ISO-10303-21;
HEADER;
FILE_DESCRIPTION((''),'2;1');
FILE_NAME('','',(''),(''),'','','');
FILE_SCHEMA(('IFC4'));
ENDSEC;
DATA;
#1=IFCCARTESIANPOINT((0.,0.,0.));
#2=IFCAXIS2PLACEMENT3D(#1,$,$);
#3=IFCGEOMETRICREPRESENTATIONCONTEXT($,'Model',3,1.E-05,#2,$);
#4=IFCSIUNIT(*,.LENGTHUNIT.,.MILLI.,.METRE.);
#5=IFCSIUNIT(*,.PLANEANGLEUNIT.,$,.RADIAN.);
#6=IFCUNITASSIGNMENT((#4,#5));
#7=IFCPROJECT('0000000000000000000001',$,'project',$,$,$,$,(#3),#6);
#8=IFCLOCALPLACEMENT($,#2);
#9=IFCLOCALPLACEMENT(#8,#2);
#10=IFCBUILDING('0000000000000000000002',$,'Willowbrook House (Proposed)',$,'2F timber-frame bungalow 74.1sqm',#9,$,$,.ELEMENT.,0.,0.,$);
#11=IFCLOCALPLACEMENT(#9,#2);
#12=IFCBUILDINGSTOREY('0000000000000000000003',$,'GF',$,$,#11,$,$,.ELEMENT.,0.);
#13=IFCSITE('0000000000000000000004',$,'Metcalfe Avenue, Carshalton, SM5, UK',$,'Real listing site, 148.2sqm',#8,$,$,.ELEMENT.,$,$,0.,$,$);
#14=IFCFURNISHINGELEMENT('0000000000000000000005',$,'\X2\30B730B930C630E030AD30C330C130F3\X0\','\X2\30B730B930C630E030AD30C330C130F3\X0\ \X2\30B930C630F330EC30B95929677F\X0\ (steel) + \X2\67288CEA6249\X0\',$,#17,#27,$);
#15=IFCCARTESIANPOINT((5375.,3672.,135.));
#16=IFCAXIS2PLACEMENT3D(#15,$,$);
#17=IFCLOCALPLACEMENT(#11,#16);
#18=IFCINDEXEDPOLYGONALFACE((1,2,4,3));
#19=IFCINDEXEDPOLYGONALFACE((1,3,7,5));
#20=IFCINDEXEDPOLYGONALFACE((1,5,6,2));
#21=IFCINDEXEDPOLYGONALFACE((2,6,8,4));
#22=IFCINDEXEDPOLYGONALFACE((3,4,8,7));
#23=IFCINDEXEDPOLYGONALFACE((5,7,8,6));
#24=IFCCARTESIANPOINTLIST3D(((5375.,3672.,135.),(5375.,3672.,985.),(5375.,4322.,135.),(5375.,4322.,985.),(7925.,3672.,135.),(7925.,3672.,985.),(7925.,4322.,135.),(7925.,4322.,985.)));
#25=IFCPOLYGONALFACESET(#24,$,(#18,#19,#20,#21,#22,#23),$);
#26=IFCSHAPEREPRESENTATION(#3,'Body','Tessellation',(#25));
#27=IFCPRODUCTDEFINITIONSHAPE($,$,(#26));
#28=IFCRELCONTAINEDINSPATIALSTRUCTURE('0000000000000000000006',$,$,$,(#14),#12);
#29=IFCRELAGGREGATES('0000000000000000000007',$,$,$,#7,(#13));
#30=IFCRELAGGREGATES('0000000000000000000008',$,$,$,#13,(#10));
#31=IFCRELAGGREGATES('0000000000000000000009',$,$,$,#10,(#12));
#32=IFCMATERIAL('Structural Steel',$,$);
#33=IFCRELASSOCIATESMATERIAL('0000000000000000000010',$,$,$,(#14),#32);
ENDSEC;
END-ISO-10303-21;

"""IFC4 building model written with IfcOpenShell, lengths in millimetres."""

from ifc_helpers import new_model, si_unit, frame, frame_2d, origin, place, context, project, spatial, rectangle, extrude, material, element, save


model = new_model("IFC4")

# Units and contexts
model_context = context("Model", 3, precision=1e-05, world=origin())
ifc_project = project(units=[si_unit("LENGTHUNIT", "METRE", prefix="MILLI"), si_unit("PLANEANGLEUNIT", "RADIAN")], contexts=[model_context])

# Site, building, storey
site_placement = place(None, origin())
site = spatial("IfcSite", under=ifc_project, at=site_placement, Name="Metcalfe Avenue, Carshalton, SM5, UK", ObjectType="Real listing site, 148.2sqm", CompositionType="ELEMENT", RefElevation=0.0)
building_placement = place(site_placement, origin())
building = spatial("IfcBuilding", under=site, at=building_placement, Name="Willowbrook House (Proposed)", ObjectType="2F timber-frame bungalow 74.1sqm", CompositionType="ELEMENT", ElevationOfRefHeight=0.0, ElevationOfTerrain=0.0)
storey_placement = place(building_placement, origin())
storey = spatial("IfcBuildingStorey", under=building, at=storey_placement, Name="GF", CompositionType="ELEMENT", Elevation=0.0)

# Furnishing element
ifc_material_1 = material(Name="Structural Steel")
furnishing_1_placement = place(storey_placement, frame((5375.0, 3672.0, 135.0)))
element("IfcFurnishingElement", 1, at=furnishing_1_placement, inside=storey, material=ifc_material_1, Name="システムキッチン", Description="システムキッチン ステンレス天板 (steel) + 木質扉", context=model_context, shape_type="SweptSolid", body=[
    extrude(rectangle(XDim=2550.0, YDim=650.0, at=frame_2d((1275.0, 325.0))), frame((5375.0, 3672.0, 135.0)), (0.0, 0.0, 1.0), 850.0),
])

save(model, "model.ifc")
